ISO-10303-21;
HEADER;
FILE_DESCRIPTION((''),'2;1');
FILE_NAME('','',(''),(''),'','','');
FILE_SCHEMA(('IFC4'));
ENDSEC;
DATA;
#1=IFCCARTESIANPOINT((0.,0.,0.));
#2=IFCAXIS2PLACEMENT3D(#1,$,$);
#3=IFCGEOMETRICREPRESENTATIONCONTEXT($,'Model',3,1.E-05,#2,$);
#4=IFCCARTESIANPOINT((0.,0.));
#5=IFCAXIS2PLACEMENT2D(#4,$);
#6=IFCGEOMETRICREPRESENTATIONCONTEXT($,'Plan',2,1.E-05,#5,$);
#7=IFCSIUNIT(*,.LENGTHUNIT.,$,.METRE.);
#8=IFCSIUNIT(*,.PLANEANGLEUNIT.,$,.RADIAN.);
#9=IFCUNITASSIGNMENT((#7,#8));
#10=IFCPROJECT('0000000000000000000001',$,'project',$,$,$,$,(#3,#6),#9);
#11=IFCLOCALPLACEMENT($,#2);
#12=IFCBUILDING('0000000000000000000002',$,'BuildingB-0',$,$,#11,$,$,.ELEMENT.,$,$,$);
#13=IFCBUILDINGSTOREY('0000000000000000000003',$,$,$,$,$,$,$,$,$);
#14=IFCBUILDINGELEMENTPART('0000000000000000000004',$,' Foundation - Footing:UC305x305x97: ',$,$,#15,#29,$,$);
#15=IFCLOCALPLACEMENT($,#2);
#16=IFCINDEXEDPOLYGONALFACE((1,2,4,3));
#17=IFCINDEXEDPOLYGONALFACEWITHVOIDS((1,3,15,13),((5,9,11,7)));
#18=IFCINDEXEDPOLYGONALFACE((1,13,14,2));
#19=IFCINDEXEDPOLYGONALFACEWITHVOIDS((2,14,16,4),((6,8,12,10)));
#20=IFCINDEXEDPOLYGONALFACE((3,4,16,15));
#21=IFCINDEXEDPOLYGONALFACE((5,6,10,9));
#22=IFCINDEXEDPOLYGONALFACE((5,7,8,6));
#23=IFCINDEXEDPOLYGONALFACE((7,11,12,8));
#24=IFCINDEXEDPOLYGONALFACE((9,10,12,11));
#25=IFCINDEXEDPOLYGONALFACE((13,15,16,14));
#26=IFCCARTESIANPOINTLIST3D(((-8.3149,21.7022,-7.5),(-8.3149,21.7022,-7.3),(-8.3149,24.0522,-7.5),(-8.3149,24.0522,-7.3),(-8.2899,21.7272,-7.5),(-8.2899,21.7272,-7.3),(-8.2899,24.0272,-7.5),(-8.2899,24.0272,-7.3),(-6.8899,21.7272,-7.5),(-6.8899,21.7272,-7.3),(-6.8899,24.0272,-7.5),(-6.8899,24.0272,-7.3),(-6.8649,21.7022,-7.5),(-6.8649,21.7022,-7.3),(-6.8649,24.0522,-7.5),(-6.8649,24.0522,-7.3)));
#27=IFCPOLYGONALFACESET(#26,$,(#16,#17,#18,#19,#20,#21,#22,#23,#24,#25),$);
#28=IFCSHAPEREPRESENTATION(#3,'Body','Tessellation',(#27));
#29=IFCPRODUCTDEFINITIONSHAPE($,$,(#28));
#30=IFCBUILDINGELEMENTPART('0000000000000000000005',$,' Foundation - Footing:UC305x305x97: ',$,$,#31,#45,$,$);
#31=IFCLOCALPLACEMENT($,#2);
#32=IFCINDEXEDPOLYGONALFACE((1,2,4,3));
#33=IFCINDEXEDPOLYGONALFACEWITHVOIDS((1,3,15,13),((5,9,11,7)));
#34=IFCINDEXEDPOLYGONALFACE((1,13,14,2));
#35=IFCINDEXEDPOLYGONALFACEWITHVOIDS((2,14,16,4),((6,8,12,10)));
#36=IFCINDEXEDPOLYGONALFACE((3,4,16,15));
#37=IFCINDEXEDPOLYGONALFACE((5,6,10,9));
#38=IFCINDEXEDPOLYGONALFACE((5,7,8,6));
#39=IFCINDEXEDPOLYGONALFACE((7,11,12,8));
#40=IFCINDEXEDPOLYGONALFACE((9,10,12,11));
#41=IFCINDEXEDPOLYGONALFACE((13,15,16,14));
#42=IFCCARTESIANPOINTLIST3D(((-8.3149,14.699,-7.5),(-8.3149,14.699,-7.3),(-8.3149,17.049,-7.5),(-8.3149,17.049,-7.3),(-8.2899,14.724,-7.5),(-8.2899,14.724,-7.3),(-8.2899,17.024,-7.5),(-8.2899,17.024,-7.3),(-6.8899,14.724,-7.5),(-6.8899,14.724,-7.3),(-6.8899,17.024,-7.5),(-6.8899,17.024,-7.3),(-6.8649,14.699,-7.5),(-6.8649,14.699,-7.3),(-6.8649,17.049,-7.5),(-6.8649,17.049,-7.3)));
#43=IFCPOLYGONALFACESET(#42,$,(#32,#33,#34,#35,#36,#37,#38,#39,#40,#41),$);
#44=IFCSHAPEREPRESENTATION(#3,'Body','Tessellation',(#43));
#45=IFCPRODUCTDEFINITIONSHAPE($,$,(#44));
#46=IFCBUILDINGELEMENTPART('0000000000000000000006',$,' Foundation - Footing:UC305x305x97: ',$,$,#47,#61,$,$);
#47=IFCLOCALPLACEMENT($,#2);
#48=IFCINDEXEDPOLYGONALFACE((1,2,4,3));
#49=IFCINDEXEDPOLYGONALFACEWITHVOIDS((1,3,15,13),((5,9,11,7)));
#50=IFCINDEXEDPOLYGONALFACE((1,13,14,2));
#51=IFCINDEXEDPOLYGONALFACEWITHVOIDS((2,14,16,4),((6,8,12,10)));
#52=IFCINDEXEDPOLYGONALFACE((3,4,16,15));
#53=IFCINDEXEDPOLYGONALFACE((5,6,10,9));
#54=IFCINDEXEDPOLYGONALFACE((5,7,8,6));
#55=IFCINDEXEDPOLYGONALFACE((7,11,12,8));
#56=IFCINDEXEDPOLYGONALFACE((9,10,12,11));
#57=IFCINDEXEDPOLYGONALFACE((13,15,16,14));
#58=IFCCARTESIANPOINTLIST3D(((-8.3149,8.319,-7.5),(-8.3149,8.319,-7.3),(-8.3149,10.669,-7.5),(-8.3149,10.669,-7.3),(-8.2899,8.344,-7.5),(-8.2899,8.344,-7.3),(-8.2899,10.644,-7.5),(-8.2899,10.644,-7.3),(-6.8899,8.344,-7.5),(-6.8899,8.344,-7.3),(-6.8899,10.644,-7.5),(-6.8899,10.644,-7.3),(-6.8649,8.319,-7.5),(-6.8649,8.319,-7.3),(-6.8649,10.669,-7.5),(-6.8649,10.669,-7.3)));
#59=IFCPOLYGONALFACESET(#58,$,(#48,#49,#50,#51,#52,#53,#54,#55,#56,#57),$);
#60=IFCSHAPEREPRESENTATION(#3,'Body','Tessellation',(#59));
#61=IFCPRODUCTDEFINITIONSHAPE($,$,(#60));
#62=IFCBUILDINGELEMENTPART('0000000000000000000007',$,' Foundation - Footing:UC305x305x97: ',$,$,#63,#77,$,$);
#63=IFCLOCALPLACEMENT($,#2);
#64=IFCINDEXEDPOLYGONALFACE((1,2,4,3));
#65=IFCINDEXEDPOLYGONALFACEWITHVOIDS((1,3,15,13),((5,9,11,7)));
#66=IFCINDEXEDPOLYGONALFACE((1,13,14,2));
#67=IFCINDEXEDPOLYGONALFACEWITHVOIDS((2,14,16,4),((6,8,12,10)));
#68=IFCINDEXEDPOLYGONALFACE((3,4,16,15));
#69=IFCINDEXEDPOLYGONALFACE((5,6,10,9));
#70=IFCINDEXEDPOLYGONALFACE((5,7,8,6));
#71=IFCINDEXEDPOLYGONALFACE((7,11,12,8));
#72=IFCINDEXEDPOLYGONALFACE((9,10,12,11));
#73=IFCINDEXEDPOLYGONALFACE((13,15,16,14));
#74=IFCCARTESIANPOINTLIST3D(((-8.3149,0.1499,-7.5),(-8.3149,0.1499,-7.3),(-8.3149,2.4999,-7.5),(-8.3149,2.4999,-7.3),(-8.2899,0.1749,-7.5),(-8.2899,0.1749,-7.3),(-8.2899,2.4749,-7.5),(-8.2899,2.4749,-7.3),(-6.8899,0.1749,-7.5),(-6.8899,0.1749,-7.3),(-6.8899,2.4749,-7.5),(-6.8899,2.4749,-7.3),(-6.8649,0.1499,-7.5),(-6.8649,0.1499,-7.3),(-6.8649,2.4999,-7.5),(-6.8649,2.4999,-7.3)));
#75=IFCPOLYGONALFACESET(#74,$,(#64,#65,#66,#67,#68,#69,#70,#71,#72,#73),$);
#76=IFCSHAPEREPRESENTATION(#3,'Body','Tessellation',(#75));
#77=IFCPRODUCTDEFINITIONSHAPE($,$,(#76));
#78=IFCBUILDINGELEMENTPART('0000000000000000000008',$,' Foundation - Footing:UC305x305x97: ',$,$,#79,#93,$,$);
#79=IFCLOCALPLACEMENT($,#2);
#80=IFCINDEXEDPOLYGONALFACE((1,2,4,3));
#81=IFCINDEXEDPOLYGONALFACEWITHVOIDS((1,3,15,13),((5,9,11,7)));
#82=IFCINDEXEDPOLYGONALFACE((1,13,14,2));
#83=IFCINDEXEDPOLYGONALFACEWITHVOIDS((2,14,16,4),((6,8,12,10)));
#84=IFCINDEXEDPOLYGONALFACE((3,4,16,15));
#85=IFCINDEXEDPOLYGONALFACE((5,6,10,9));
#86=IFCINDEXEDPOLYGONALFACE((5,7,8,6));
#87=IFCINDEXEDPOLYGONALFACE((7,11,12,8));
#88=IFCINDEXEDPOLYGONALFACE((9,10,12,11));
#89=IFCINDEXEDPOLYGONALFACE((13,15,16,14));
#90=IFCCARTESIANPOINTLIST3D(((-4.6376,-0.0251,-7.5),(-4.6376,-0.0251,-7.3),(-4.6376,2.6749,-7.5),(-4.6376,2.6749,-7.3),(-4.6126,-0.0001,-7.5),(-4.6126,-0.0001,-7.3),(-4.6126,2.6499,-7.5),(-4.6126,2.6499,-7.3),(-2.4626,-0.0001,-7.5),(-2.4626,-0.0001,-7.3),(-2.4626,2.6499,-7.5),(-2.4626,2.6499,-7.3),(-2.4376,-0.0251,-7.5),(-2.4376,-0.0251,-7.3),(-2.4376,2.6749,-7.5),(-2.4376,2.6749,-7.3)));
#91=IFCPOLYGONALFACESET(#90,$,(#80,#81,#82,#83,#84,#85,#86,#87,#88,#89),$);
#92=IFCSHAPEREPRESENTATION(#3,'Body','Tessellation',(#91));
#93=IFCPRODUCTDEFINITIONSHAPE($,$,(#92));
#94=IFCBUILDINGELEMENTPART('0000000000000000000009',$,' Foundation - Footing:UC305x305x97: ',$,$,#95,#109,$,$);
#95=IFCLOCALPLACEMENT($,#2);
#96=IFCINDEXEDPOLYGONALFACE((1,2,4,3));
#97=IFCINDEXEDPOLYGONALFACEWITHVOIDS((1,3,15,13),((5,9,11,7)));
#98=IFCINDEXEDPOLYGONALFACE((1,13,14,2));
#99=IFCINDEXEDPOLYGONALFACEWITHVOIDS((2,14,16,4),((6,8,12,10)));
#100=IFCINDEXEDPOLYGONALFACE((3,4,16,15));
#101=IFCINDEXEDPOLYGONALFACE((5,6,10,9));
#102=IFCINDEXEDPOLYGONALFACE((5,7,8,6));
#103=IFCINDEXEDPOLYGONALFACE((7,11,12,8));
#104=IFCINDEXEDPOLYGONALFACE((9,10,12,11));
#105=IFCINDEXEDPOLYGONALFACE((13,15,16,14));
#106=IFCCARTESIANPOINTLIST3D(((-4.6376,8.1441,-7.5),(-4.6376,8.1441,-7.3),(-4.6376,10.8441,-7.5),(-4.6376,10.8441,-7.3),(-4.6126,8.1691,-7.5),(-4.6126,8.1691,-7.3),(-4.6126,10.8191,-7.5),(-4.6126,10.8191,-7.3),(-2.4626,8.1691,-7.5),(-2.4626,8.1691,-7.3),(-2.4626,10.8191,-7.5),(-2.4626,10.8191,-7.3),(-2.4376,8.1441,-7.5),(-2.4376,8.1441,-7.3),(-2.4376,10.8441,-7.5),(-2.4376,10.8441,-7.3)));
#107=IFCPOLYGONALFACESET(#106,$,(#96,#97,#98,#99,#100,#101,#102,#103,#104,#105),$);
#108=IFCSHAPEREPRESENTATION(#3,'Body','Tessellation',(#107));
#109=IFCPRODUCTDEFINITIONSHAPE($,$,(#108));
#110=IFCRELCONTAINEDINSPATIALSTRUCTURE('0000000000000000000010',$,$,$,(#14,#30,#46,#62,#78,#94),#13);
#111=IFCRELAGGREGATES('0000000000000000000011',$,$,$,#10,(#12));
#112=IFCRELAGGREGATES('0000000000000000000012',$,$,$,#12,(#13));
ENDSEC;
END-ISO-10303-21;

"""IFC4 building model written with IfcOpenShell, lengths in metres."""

from ifc_helpers import new_model, si_unit, origin, origin_2d, place, context, project, spatial, polyline, outline, extrude, element, save


model = new_model("IFC4")

# Units and contexts
model_context = context("Model", 3, precision=1e-05, world=origin())
plan_context = context("Plan", 2, precision=1e-05, world=origin_2d())
ifc_project = project(units=[si_unit("LENGTHUNIT", "METRE"), si_unit("PLANEANGLEUNIT", "RADIAN")], contexts=[model_context, plan_context])

# Building, storey
building_placement = place(None, origin())
building = spatial("IfcBuilding", under=ifc_project, at=building_placement, Name="BuildingB-0", CompositionType="ELEMENT")
storey = spatial("IfcBuildingStorey", under=building)

# Building element parts, openings
building_element_part_1 = element("IfcBuildingElementPart", 1, inside=storey, Name=" Foundation - Footing:UC305x305x97: ", context=model_context, shape_type="SweptSolid", body=[
    extrude(outline(polyline([(-6.8649, 24.0522, -7.5), (-8.3149, 24.0522, -7.5), (-8.3149, 21.7022, -7.5), (-6.8649, 21.7022, -7.5), (-6.8649, 24.0522, -7.5)])), None, (0.0, 0.0, 1.0), 0.2),
])
element("IfcOpeningElement", 2, inside=storey, cuts=building_element_part_1, context=model_context, shape_type="SweptSolid", body=[
    extrude(outline(polyline([(-6.8899, 24.0272, -7.5), (-8.2899, 24.0272, -7.5), (-8.2899, 21.7272, -7.5), (-6.8899, 21.7272, -7.5), (-6.8899, 24.0272, -7.5)])), None, (0.0, 0.0, 1.0), 0.2),
])
building_element_part_2 = element("IfcBuildingElementPart", 3, inside=storey, Name=" Foundation - Footing:UC305x305x97: ", context=model_context, shape_type="SweptSolid", body=[
    extrude(outline(polyline([(-8.3149, 14.699, -7.5), (-6.8649, 14.699, -7.5), (-6.8649, 17.049, -7.5), (-8.3149, 17.049, -7.5), (-8.3149, 14.699, -7.5)])), None, (0.0, 0.0, 1.0), 0.2),
])
element("IfcOpeningElement", 4, inside=storey, cuts=building_element_part_2, context=model_context, shape_type="SweptSolid", body=[
    extrude(outline(polyline([(-8.2899, 14.724, -7.5), (-6.8899, 14.724, -7.5), (-6.8899, 17.024, -7.5), (-8.2899, 17.024, -7.5), (-8.2899, 14.724, -7.5)])), None, (0.0, 0.0, 1.0), 0.2),
])
building_element_part_3 = element("IfcBuildingElementPart", 5, inside=storey, Name=" Foundation - Footing:UC305x305x97: ", context=model_context, shape_type="SweptSolid", body=[
    extrude(outline(polyline([(-8.3149, 8.319, -7.5), (-6.8649, 8.319, -7.5), (-6.8649, 10.669, -7.5), (-8.3149, 10.669, -7.5), (-8.3149, 8.319, -7.5)])), None, (0.0, 0.0, 1.0), 0.2),
])
element("IfcOpeningElement", 6, inside=storey, cuts=building_element_part_3, context=model_context, shape_type="SweptSolid", body=[
    extrude(outline(polyline([(-8.2899, 8.344, -7.5), (-6.8899, 8.344, -7.5), (-6.8899, 10.644, -7.5), (-8.2899, 10.644, -7.5), (-8.2899, 8.344, -7.5)])), None, (0.0, 0.0, 1.0), 0.2),
])
building_element_part_4 = element("IfcBuildingElementPart", 7, inside=storey, Name=" Foundation - Footing:UC305x305x97: ", context=model_context, shape_type="SweptSolid", body=[
    extrude(outline(polyline([(-8.3149, 0.1499, -7.5), (-6.8649, 0.1499, -7.5), (-6.8649, 2.4999, -7.5), (-8.3149, 2.4999, -7.5), (-8.3149, 0.1499, -7.5)])), None, (0.0, 0.0, 1.0), 0.2),
])
element("IfcOpeningElement", 8, inside=storey, cuts=building_element_part_4, context=model_context, shape_type="SweptSolid", body=[
    extrude(outline(polyline([(-8.2899, 0.1749, -7.5), (-6.8899, 0.1749, -7.5), (-6.8899, 2.4749, -7.5), (-8.2899, 2.4749, -7.5), (-8.2899, 0.1749, -7.5)])), None, (0.0, 0.0, 1.0), 0.2),
])
building_element_part_5 = element("IfcBuildingElementPart", 9, inside=storey, Name=" Foundation - Footing:UC305x305x97: ", context=model_context, shape_type="SweptSolid", body=[
    extrude(outline(polyline([(-4.6376, -0.0251, -7.5), (-2.4376, -0.0251, -7.5), (-2.4376, 2.6749, -7.5), (-4.6376, 2.6749, -7.5), (-4.6376, -0.0251, -7.5)])), None, (0.0, 0.0, 1.0), 0.2),
])
element("IfcOpeningElement", 10, inside=storey, cuts=building_element_part_5, context=model_context, shape_type="SweptSolid", body=[
    extrude(outline(polyline([(-4.6126, -0.0001, -7.5), (-2.4626, -0.0001, -7.5), (-2.4626, 2.6499, -7.5), (-4.6126, 2.6499, -7.5), (-4.6126, -0.0001, -7.5)])), None, (0.0, 0.0, 1.0), 0.2),
])
building_element_part_6 = element("IfcBuildingElementPart", 11, inside=storey, Name=" Foundation - Footing:UC305x305x97: ", context=model_context, shape_type="SweptSolid", body=[
    extrude(outline(polyline([(-4.6376, 8.1441, -7.5), (-2.4376, 8.1441, -7.5), (-2.4376, 10.8441, -7.5), (-4.6376, 10.8441, -7.5), (-4.6376, 8.1441, -7.5)])), None, (0.0, 0.0, 1.0), 0.2),
])
element("IfcOpeningElement", 12, inside=storey, cuts=building_element_part_6, context=model_context, shape_type="SweptSolid", body=[
    extrude(outline(polyline([(-4.6126, 8.1691, -7.5), (-2.4626, 8.1691, -7.5), (-2.4626, 10.8191, -7.5), (-4.6126, 10.8191, -7.5), (-4.6126, 8.1691, -7.5)])), None, (0.0, 0.0, 1.0), 0.2),
])

save(model, "model.ifc")
